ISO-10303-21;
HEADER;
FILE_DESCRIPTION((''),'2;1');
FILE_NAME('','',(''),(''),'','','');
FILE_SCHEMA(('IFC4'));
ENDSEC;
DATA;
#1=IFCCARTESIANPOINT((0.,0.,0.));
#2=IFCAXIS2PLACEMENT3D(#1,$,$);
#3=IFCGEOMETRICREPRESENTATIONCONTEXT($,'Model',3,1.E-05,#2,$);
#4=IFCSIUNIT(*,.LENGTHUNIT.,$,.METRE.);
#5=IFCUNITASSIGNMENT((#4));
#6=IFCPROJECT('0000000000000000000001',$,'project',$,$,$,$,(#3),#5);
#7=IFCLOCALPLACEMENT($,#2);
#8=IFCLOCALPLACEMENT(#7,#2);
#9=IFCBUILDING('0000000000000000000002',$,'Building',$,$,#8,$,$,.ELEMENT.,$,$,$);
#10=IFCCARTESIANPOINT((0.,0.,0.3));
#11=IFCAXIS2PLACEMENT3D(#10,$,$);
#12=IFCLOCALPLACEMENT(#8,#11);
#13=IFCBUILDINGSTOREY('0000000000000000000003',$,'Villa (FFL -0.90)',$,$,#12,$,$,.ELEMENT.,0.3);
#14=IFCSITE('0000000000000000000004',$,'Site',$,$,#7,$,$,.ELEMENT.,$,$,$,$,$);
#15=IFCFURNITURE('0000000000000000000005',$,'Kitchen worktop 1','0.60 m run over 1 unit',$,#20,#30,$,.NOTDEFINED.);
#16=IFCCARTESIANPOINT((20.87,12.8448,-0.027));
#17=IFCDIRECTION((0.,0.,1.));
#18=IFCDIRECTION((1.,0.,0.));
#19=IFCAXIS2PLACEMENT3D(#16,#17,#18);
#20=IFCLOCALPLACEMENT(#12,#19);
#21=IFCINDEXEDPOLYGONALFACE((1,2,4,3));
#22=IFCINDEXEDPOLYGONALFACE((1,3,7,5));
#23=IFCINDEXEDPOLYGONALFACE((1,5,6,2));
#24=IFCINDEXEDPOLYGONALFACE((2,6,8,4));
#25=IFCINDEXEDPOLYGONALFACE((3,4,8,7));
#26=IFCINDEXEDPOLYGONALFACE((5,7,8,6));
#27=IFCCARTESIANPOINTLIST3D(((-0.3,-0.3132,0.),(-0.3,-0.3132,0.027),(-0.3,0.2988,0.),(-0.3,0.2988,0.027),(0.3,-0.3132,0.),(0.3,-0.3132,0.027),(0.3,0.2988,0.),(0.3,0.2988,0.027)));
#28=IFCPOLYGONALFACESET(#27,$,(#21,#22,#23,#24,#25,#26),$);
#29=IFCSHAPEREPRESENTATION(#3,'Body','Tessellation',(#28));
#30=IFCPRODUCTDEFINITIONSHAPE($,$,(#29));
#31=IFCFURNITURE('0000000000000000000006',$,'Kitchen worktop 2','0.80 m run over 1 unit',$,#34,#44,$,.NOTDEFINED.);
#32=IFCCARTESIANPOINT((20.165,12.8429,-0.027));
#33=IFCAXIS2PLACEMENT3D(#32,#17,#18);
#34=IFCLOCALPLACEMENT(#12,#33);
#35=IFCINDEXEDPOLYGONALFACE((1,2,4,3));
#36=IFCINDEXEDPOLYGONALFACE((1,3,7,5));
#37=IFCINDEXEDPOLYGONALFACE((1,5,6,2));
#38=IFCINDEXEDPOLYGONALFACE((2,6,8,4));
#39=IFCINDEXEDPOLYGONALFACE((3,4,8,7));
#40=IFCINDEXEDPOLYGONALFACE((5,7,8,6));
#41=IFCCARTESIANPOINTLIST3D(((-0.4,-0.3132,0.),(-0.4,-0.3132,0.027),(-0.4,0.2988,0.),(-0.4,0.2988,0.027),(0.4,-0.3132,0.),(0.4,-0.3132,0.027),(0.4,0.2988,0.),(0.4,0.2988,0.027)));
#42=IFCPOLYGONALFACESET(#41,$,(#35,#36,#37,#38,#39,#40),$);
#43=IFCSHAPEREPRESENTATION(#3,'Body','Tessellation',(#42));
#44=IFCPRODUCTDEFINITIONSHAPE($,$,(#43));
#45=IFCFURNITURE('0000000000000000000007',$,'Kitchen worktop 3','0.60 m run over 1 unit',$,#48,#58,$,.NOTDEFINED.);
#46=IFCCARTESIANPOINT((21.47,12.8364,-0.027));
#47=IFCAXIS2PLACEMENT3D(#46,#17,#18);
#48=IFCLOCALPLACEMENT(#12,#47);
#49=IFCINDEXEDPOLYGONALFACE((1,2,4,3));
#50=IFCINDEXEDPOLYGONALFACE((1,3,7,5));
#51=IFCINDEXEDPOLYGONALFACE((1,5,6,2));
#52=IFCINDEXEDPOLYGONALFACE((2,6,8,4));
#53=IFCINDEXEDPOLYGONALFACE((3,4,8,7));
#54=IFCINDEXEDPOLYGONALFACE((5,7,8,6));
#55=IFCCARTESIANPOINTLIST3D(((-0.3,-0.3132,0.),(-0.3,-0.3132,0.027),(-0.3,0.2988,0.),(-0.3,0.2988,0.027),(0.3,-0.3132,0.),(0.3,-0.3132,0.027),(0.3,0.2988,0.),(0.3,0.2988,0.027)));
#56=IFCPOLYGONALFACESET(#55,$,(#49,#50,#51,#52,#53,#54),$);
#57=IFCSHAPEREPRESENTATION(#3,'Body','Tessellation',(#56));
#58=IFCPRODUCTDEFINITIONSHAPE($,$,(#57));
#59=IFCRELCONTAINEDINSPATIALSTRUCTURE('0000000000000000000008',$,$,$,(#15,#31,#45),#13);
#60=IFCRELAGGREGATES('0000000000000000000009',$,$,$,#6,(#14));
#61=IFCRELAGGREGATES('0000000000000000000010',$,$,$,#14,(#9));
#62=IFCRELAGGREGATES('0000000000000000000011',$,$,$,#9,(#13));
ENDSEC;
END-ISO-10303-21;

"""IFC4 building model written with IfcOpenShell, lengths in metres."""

from ifc_helpers import new_model, si_unit, frame, frame_2d, origin, place, context, project, spatial, rectangle, extrude, element, save


model = new_model("IFC4")

# Units and contexts
model_context = context("Model", 3, precision=1e-05, world=origin())
ifc_project = project(units=[si_unit("LENGTHUNIT", "METRE")], contexts=[model_context])

# Site, building, storey
site_placement = place(None, origin())
site = spatial("IfcSite", under=ifc_project, at=site_placement, Name="Site", CompositionType="ELEMENT")
building_placement = place(site_placement, origin())
building = spatial("IfcBuilding", under=site, at=building_placement, Name="Building", CompositionType="ELEMENT")
storey_placement = place(building_placement, frame((0.0, 0.0, 0.3)))
storey = spatial("IfcBuildingStorey", under=building, at=storey_placement, Name="Villa (FFL -0.90)", CompositionType="ELEMENT", Elevation=0.3)

# Furniture
furniture_1_placement = place(storey_placement, frame((20.87, 12.8448, -0.027), z_axis=(0.0, 0.0, 1.0), x_axis=(1.0, 0.0, 0.0)))
element("IfcFurniture", 1, at=furniture_1_placement, inside=storey, Name="Kitchen worktop 1", Description="0.60 m run over 1 unit", PredefinedType="NOTDEFINED", context=model_context, shape_type="SweptSolid", body=[
    extrude(rectangle(XDim=0.6, YDim=0.612, at=frame_2d((0.0, -0.0072))), origin(), (0.0, 0.0, 1.0), 0.027),
])
furniture_2_placement = place(storey_placement, frame((20.165, 12.8429, -0.027), z_axis=(0.0, 0.0, 1.0), x_axis=(1.0, 0.0, 0.0)))
element("IfcFurniture", 2, at=furniture_2_placement, inside=storey, Name="Kitchen worktop 2", Description="0.80 m run over 1 unit", PredefinedType="NOTDEFINED", context=model_context, shape_type="SweptSolid", body=[
    extrude(rectangle(XDim=0.8, YDim=0.612, at=frame_2d((0.0, -0.0072))), origin(), (0.0, 0.0, 1.0), 0.027),
])
furniture_3_placement = place(storey_placement, frame((21.47, 12.8364, -0.027), z_axis=(0.0, 0.0, 1.0), x_axis=(1.0, 0.0, 0.0)))
element("IfcFurniture", 3, at=furniture_3_placement, inside=storey, Name="Kitchen worktop 3", Description="0.60 m run over 1 unit", PredefinedType="NOTDEFINED", context=model_context, shape_type="SweptSolid", body=[
    extrude(rectangle(XDim=0.6, YDim=0.612, at=frame_2d((0.0, -0.0072))), origin(), (0.0, 0.0, 1.0), 0.027),
])

save(model, "model.ifc")
